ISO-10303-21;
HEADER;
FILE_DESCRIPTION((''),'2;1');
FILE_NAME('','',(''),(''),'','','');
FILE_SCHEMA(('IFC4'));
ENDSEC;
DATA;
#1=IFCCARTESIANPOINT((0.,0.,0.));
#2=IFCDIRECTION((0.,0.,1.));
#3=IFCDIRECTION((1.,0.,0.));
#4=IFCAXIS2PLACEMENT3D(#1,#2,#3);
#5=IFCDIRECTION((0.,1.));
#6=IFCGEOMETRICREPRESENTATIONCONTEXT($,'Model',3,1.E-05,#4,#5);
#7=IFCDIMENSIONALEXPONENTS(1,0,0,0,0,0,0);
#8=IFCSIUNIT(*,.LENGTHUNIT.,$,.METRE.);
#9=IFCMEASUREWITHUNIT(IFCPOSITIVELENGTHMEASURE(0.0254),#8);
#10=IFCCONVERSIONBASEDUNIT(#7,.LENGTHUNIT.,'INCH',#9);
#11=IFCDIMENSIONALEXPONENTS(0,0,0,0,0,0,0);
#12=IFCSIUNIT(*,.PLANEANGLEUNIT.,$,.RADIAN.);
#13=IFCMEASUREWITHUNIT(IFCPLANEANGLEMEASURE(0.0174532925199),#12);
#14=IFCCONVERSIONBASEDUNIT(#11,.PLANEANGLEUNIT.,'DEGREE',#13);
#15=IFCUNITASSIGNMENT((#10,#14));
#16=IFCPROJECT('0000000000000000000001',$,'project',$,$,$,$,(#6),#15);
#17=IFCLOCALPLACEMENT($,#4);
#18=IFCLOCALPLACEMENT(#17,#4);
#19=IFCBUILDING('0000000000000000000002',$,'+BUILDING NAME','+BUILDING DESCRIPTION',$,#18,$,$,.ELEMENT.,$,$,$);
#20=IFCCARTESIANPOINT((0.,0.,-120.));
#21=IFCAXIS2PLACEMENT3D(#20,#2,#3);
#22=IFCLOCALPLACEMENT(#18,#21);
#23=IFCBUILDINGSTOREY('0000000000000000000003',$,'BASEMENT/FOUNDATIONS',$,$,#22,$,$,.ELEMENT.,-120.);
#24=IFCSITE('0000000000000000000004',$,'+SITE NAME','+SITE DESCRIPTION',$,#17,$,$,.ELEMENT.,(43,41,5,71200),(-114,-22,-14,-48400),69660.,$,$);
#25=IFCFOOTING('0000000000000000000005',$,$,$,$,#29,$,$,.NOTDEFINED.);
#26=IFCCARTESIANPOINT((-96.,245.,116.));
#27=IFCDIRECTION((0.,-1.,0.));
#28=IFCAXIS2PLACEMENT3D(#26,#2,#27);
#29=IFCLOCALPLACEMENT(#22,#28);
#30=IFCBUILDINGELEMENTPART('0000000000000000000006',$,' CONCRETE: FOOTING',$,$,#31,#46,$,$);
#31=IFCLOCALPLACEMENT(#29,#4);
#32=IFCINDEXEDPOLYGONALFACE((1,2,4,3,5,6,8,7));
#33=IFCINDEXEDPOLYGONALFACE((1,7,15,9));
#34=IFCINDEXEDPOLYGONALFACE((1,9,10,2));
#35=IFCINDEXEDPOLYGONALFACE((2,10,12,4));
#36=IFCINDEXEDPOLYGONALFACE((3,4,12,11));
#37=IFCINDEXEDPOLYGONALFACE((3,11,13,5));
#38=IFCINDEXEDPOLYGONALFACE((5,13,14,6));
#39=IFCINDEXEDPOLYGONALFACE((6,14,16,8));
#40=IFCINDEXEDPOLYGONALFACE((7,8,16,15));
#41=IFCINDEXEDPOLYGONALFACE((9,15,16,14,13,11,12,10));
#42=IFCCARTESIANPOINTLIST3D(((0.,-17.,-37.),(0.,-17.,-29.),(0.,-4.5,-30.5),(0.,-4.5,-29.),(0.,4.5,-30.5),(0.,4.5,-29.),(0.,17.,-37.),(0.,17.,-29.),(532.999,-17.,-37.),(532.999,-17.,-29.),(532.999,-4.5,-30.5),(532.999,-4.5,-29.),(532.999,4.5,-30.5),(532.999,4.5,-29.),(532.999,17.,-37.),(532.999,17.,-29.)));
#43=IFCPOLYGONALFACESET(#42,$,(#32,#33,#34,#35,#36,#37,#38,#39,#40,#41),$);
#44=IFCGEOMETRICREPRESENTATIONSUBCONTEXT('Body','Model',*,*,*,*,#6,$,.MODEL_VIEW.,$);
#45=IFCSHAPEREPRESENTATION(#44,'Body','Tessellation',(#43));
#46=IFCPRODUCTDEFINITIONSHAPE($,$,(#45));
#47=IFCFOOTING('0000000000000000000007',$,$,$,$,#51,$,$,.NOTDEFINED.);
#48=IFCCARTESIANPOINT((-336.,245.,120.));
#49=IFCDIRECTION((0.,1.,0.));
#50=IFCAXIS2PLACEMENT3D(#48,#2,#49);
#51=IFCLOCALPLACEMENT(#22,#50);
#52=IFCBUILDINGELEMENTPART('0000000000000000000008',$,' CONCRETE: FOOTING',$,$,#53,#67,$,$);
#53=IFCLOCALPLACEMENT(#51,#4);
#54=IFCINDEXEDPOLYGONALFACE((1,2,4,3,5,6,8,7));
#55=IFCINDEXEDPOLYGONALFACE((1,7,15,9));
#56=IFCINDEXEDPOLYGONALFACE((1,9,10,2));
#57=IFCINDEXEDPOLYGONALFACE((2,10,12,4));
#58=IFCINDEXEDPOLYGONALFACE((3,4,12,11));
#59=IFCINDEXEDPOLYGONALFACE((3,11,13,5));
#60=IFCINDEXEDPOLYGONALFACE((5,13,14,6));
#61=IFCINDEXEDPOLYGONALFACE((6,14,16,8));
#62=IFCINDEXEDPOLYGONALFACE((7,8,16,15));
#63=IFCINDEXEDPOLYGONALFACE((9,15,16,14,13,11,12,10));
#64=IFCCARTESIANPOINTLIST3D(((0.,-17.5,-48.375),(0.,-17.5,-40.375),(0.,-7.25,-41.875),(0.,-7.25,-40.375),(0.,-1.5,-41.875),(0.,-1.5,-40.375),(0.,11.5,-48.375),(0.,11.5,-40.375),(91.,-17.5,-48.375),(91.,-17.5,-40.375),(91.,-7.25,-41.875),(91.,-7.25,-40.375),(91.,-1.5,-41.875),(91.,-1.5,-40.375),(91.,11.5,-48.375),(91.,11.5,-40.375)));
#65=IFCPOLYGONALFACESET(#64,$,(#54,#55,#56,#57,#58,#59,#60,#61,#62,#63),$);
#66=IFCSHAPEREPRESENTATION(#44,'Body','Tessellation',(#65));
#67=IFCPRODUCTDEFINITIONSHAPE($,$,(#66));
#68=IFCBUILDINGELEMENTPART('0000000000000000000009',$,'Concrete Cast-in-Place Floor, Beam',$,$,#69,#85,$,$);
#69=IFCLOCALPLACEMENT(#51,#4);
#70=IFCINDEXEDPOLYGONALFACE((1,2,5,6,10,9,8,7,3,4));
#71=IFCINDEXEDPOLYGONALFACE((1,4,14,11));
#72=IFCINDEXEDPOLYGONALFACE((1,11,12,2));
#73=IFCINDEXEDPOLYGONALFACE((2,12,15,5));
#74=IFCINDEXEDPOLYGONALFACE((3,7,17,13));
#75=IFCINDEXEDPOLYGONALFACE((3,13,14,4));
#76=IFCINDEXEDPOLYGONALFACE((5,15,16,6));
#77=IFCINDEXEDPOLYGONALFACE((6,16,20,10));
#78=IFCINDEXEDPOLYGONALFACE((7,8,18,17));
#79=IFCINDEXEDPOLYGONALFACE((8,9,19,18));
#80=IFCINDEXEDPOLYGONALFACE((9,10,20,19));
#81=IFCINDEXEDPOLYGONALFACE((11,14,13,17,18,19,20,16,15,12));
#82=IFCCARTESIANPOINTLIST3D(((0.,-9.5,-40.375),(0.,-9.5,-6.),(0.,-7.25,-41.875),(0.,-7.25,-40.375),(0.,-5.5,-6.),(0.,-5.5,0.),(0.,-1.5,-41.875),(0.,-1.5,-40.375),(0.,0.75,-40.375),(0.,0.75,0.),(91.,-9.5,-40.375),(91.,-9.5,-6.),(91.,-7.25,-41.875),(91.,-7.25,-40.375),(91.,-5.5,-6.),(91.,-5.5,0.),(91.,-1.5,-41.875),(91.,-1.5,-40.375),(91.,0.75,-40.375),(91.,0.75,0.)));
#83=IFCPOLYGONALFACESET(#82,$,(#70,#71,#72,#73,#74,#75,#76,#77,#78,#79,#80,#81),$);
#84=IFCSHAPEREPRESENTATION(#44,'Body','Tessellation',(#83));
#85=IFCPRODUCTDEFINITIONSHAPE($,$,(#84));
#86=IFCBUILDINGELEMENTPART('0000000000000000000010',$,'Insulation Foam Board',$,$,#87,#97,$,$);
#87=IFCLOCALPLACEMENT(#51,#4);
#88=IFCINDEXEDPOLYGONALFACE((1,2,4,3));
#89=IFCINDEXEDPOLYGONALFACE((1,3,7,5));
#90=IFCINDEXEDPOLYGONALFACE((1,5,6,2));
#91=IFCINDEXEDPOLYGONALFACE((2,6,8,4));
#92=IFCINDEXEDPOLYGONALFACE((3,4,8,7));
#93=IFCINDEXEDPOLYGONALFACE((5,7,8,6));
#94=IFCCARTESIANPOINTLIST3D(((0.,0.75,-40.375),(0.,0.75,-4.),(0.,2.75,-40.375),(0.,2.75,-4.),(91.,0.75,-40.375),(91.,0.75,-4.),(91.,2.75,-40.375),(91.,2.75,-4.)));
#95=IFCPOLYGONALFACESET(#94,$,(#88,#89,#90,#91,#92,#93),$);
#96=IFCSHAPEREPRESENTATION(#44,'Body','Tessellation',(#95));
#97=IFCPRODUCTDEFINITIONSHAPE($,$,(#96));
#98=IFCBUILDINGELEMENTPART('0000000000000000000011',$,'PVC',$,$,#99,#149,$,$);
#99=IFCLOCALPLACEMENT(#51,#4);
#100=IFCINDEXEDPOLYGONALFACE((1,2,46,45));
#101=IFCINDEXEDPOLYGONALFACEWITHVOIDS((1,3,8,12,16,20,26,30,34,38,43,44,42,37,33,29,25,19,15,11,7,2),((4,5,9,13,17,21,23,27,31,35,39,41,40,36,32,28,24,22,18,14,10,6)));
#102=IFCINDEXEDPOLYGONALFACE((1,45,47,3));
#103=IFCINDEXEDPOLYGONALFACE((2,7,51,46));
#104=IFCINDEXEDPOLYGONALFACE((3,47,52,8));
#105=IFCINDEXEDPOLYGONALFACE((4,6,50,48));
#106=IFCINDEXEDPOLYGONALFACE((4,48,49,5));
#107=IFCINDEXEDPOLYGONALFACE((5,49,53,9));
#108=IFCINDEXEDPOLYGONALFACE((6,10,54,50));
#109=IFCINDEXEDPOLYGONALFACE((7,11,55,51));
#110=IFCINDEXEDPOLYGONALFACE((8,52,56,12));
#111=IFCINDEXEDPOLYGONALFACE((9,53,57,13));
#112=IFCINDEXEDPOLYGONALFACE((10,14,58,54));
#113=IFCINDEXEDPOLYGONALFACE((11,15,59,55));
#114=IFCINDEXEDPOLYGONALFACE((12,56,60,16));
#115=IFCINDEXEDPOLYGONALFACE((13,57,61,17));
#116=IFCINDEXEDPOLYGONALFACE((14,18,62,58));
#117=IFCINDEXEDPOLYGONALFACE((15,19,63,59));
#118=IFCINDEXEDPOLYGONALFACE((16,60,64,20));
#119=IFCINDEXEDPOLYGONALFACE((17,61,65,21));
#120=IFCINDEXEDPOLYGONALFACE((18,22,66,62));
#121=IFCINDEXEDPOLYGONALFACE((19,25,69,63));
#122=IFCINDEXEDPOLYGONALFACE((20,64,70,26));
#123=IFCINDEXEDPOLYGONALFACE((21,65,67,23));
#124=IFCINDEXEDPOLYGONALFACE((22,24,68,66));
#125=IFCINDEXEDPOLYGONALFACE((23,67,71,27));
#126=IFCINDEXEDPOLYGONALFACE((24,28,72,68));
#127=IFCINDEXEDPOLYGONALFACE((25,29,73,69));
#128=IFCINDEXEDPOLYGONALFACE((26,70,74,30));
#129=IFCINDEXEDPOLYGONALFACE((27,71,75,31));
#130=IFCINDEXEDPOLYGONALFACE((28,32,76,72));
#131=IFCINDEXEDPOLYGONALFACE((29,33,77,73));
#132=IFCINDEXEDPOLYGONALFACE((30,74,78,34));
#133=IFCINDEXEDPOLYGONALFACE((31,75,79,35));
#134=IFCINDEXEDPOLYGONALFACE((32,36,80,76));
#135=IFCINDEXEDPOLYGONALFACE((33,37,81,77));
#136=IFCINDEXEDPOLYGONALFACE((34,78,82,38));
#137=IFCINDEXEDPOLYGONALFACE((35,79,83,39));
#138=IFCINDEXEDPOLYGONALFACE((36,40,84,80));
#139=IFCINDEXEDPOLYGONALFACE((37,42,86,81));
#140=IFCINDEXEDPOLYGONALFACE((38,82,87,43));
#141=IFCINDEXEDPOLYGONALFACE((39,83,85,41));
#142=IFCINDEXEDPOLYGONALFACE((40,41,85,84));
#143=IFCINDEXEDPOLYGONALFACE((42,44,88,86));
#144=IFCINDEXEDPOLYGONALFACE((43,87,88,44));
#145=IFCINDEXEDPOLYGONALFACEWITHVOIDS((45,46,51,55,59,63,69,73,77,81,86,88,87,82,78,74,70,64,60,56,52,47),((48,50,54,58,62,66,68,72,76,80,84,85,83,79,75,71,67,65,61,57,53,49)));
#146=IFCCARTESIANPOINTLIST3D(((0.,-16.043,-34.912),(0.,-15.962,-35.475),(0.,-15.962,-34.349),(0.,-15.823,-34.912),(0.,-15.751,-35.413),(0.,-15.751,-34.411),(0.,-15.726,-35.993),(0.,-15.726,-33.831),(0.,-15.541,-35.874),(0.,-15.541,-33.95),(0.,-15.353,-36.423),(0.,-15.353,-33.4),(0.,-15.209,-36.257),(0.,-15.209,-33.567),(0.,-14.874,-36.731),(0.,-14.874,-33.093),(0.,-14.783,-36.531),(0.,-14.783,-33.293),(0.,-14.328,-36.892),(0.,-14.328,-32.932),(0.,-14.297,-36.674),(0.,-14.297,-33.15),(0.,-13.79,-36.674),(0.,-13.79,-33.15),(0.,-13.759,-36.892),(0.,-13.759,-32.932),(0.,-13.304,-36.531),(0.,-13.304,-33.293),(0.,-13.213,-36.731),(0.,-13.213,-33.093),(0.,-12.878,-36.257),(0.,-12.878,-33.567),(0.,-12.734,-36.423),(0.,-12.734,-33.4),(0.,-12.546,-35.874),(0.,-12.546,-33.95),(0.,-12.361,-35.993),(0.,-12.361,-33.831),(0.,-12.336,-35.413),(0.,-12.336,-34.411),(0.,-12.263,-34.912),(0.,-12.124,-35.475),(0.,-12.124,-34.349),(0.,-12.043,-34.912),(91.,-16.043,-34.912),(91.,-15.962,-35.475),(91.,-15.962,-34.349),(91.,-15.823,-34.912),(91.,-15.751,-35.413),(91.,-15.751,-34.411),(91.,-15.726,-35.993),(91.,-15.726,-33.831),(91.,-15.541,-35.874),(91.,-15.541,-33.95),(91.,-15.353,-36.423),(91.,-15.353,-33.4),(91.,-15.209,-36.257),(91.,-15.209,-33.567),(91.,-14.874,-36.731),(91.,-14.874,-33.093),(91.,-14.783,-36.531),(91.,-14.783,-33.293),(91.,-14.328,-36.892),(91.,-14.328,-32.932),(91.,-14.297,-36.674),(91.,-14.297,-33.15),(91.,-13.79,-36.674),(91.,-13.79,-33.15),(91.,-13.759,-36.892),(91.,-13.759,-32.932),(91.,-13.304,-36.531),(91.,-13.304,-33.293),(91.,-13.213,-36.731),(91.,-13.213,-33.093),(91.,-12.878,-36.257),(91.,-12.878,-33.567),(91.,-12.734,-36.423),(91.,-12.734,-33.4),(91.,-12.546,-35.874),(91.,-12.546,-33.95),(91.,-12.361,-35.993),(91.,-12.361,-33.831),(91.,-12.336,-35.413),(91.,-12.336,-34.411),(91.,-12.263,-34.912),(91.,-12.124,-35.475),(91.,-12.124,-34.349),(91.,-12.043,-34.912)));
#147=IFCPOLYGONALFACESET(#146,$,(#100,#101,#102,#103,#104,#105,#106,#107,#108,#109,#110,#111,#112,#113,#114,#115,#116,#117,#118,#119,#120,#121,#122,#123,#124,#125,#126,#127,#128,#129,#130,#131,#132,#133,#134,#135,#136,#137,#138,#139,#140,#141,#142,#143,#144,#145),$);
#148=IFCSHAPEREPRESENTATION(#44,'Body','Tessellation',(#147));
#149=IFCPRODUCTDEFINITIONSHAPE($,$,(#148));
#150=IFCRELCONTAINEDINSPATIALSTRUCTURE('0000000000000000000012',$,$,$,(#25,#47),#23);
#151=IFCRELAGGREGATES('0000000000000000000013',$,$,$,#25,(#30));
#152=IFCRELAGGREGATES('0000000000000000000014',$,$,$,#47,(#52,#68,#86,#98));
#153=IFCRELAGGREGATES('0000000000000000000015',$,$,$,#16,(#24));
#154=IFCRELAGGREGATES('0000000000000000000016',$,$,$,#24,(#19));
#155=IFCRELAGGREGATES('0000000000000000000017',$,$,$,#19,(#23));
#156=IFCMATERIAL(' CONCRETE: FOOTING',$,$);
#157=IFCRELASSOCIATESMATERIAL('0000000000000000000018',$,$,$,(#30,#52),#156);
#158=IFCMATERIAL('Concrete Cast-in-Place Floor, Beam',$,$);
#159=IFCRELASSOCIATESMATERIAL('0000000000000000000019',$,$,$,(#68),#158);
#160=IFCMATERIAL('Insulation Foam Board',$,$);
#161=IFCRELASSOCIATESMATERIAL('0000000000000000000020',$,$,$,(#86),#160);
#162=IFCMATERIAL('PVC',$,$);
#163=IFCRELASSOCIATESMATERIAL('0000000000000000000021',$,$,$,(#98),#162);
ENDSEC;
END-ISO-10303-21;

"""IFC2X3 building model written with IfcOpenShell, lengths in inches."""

from ifc_helpers import new_model, entity, si_unit, converted_unit, point, direction, frame, frame_2d, origin_with_axes, place, context, subcontext, project, spatial, polyline, circle_curve, parameter, trimmed, segment, composite_curve, outline, extrude, material, element, aggregate, save


model = new_model("IFC2X3")

# Units and contexts
model_context = context("Model", 3, precision=1e-05, world=origin_with_axes(), true_north=direction((0.0, 1.0)))
body_context = subcontext(model_context, "Body", "Model", "MODEL_VIEW")
ifc_project = project(units=[converted_unit("LENGTHUNIT", "INCH", entity("IfcPositiveLengthMeasure", 0.0254), si_unit("LENGTHUNIT", "METRE"), dimensions=[1, 0, 0, 0, 0, 0, 0]), converted_unit("PLANEANGLEUNIT", "DEGREE", entity("IfcPlaneAngleMeasure", 0.0174532925199), si_unit("PLANEANGLEUNIT", "RADIAN"), dimensions=[0, 0, 0, 0, 0, 0, 0])], contexts=[model_context])

# Site, building, storey
site_placement = place(None, origin_with_axes())
site = spatial("IfcSite", under=ifc_project, at=site_placement, Name="+SITE NAME", Description="+SITE DESCRIPTION", CompositionType="ELEMENT", RefLatitude=(43, 41, 5, 71200), RefLongitude=(-114, -22, -14, -48400), RefElevation=69660.0)
building_placement = place(site_placement, origin_with_axes())
building = spatial("IfcBuilding", under=site, at=building_placement, Name="+BUILDING NAME", Description="+BUILDING DESCRIPTION", CompositionType="ELEMENT")
storey_placement = place(building_placement, frame((0.0, 0.0, -120.0), z_axis=(0.0, 0.0, 1.0), x_axis=(1.0, 0.0, 0.0)))
storey = spatial("IfcBuildingStorey", under=building, at=storey_placement, Name="BASEMENT/FOUNDATIONS", CompositionType="ELEMENT", Elevation=-120.0)

# Footings, building element parts
footing_1_placement = place(storey_placement, frame((-96.0, 245.0, 116.0), z_axis=(0.0, 0.0, 1.0), x_axis=(0.0, -1.0, 0.0)))
footing_1 = element("IfcFooting", 1, at=footing_1_placement, inside=storey, PredefinedType="NOTDEFINED")
ifc_material_1 = material(Name=" CONCRETE: FOOTING")
building_element_part_1_placement = place(footing_1_placement, origin_with_axes())
building_element_part_1 = element("IfcBuildingElementPart", 2, at=building_element_part_1_placement, material=ifc_material_1, Name=" CONCRETE: FOOTING", context=body_context, shape_type="SweptSolid", body=[
    extrude(outline(polyline([(-17.0, -37.0), (17.0, -37.0), (17.0, -29.0), (4.5, -29.0), (4.5, -30.5), (-4.5, -30.5), (-4.5, -29.0), (-17.0, -29.0), (-17.0, -37.0)])), frame((0.0, 0.0, 0.0), z_axis=(1.0, 0.0, 0.0), x_axis=(0.0, 1.0, 0.0)), (0.0, 0.0, 1.0), 532.999),
])
ifc_material_2 = material(Name="Concrete Cast-in-Place Floor, Beam")
aggregate(footing_1, [building_element_part_1])
footing_2_placement = place(storey_placement, frame((-336.0, 245.0, 120.0), z_axis=(0.0, 0.0, 1.0), x_axis=(0.0, 1.0, 0.0)))
footing_2 = element("IfcFooting", 3, at=footing_2_placement, inside=storey, PredefinedType="NOTDEFINED")
building_element_part_2_placement = place(footing_2_placement, origin_with_axes())
building_element_part_2 = element("IfcBuildingElementPart", 4, at=building_element_part_2_placement, material=ifc_material_1, Name=" CONCRETE: FOOTING", context=body_context, shape_type="SweptSolid", body=[
    extrude(outline(polyline([(-11.5, -48.375), (17.5, -48.375), (17.5, -40.375), (7.25, -40.375), (7.25, -41.875), (1.5, -41.875), (1.5, -40.375), (-11.5, -40.375), (-11.5, -48.375)])), frame((0.0, 0.0, 0.0), z_axis=(-1.0, 0.0, 0.0), x_axis=(0.0, -1.0, 0.0)), (0.0, 0.0, -1.0), 91.0),
])
building_element_part_3_placement = place(footing_2_placement, origin_with_axes())
building_element_part_3 = element("IfcBuildingElementPart", 5, at=building_element_part_3_placement, material=ifc_material_2, Name="Concrete Cast-in-Place Floor, Beam", context=body_context, shape_type="SweptSolid", body=[
    extrude(outline(polyline([(-0.75, 0.0), (-0.75, -40.375), (1.5, -40.375), (1.5, -41.875), (7.25, -41.875), (7.25, -40.375), (9.5, -40.375), (9.5, -6.0), (5.5, -6.0), (5.5, 0.0), (-0.75, 0.0)])), frame((0.0, 0.0, 0.0), z_axis=(-1.0, 0.0, 0.0), x_axis=(0.0, -1.0, 0.0)), (0.0, 0.0, -1.0), 91.0),
])
ifc_material_3 = material(Name="Insulation Foam Board")
building_element_part_4_placement = place(footing_2_placement, origin_with_axes())
building_element_part_4 = element("IfcBuildingElementPart", 6, at=building_element_part_4_placement, material=ifc_material_3, Name="Insulation Foam Board", context=body_context, shape_type="SweptSolid", body=[
    extrude(outline(polyline([(-0.75, -4.0), (-2.75, -4.0), (-2.75, -40.375), (-0.75, -40.375), (-0.75, -4.0)])), frame((0.0, 0.0, 0.0), z_axis=(-1.0, 0.0, 0.0), x_axis=(0.0, -1.0, 0.0)), (0.0, 0.0, -1.0), 91.0),
])
ifc_material_4 = material(Name="PVC")
building_element_part_5_placement = place(footing_2_placement, origin_with_axes())
building_element_part_5 = element("IfcBuildingElementPart", 7, at=building_element_part_5_placement, material=ifc_material_4, Name="PVC", context=body_context, shape_type="SweptSolid", body=[
    extrude(outline(composite_curve([segment(trimmed(circle_curve(frame_2d((14.043, -34.912), x_axis=(1.0, 0.0)), 2.0), [point((16.043, -34.912)), parameter(0.0)], [point((12.043, -34.912)), parameter(180.0)], True, "CARTESIAN"), True, "CONTINUOUS"), segment(trimmed(circle_curve(frame_2d((14.043, -34.912), x_axis=(-1.0, 0.0)), 2.0), [point((12.043, -34.912)), parameter(0.0)], [point((16.043, -34.912)), parameter(180.0)], True, "CARTESIAN"), True, "CONTINUOUS")], self_intersect=False), holes=[composite_curve([segment(trimmed(circle_curve(frame_2d((14.043, -34.912), x_axis=(-1.0, 0.0)), 1.78), [point((15.823, -34.912)), parameter(180.0)], [point((12.263, -34.912)), parameter(0.0)], False, "CARTESIAN"), True, "CONTINUOUS"), segment(trimmed(circle_curve(frame_2d((14.043, -34.912), x_axis=(1.0, 0.0)), 1.78), [point((12.263, -34.912)), parameter(180.0)], [point((15.823, -34.912)), parameter(0.0)], False, "CARTESIAN"), True, "CONTINUOUS")], self_intersect=False)]), frame((0.0, 0.0, 0.0), z_axis=(-1.0, 0.0, 0.0), x_axis=(0.0, -1.0, 0.0)), (0.0, 0.0, -1.0), 91.0),
])
aggregate(footing_2, [building_element_part_2, building_element_part_3, building_element_part_4, building_element_part_5])

save(model, "model.ifc")
